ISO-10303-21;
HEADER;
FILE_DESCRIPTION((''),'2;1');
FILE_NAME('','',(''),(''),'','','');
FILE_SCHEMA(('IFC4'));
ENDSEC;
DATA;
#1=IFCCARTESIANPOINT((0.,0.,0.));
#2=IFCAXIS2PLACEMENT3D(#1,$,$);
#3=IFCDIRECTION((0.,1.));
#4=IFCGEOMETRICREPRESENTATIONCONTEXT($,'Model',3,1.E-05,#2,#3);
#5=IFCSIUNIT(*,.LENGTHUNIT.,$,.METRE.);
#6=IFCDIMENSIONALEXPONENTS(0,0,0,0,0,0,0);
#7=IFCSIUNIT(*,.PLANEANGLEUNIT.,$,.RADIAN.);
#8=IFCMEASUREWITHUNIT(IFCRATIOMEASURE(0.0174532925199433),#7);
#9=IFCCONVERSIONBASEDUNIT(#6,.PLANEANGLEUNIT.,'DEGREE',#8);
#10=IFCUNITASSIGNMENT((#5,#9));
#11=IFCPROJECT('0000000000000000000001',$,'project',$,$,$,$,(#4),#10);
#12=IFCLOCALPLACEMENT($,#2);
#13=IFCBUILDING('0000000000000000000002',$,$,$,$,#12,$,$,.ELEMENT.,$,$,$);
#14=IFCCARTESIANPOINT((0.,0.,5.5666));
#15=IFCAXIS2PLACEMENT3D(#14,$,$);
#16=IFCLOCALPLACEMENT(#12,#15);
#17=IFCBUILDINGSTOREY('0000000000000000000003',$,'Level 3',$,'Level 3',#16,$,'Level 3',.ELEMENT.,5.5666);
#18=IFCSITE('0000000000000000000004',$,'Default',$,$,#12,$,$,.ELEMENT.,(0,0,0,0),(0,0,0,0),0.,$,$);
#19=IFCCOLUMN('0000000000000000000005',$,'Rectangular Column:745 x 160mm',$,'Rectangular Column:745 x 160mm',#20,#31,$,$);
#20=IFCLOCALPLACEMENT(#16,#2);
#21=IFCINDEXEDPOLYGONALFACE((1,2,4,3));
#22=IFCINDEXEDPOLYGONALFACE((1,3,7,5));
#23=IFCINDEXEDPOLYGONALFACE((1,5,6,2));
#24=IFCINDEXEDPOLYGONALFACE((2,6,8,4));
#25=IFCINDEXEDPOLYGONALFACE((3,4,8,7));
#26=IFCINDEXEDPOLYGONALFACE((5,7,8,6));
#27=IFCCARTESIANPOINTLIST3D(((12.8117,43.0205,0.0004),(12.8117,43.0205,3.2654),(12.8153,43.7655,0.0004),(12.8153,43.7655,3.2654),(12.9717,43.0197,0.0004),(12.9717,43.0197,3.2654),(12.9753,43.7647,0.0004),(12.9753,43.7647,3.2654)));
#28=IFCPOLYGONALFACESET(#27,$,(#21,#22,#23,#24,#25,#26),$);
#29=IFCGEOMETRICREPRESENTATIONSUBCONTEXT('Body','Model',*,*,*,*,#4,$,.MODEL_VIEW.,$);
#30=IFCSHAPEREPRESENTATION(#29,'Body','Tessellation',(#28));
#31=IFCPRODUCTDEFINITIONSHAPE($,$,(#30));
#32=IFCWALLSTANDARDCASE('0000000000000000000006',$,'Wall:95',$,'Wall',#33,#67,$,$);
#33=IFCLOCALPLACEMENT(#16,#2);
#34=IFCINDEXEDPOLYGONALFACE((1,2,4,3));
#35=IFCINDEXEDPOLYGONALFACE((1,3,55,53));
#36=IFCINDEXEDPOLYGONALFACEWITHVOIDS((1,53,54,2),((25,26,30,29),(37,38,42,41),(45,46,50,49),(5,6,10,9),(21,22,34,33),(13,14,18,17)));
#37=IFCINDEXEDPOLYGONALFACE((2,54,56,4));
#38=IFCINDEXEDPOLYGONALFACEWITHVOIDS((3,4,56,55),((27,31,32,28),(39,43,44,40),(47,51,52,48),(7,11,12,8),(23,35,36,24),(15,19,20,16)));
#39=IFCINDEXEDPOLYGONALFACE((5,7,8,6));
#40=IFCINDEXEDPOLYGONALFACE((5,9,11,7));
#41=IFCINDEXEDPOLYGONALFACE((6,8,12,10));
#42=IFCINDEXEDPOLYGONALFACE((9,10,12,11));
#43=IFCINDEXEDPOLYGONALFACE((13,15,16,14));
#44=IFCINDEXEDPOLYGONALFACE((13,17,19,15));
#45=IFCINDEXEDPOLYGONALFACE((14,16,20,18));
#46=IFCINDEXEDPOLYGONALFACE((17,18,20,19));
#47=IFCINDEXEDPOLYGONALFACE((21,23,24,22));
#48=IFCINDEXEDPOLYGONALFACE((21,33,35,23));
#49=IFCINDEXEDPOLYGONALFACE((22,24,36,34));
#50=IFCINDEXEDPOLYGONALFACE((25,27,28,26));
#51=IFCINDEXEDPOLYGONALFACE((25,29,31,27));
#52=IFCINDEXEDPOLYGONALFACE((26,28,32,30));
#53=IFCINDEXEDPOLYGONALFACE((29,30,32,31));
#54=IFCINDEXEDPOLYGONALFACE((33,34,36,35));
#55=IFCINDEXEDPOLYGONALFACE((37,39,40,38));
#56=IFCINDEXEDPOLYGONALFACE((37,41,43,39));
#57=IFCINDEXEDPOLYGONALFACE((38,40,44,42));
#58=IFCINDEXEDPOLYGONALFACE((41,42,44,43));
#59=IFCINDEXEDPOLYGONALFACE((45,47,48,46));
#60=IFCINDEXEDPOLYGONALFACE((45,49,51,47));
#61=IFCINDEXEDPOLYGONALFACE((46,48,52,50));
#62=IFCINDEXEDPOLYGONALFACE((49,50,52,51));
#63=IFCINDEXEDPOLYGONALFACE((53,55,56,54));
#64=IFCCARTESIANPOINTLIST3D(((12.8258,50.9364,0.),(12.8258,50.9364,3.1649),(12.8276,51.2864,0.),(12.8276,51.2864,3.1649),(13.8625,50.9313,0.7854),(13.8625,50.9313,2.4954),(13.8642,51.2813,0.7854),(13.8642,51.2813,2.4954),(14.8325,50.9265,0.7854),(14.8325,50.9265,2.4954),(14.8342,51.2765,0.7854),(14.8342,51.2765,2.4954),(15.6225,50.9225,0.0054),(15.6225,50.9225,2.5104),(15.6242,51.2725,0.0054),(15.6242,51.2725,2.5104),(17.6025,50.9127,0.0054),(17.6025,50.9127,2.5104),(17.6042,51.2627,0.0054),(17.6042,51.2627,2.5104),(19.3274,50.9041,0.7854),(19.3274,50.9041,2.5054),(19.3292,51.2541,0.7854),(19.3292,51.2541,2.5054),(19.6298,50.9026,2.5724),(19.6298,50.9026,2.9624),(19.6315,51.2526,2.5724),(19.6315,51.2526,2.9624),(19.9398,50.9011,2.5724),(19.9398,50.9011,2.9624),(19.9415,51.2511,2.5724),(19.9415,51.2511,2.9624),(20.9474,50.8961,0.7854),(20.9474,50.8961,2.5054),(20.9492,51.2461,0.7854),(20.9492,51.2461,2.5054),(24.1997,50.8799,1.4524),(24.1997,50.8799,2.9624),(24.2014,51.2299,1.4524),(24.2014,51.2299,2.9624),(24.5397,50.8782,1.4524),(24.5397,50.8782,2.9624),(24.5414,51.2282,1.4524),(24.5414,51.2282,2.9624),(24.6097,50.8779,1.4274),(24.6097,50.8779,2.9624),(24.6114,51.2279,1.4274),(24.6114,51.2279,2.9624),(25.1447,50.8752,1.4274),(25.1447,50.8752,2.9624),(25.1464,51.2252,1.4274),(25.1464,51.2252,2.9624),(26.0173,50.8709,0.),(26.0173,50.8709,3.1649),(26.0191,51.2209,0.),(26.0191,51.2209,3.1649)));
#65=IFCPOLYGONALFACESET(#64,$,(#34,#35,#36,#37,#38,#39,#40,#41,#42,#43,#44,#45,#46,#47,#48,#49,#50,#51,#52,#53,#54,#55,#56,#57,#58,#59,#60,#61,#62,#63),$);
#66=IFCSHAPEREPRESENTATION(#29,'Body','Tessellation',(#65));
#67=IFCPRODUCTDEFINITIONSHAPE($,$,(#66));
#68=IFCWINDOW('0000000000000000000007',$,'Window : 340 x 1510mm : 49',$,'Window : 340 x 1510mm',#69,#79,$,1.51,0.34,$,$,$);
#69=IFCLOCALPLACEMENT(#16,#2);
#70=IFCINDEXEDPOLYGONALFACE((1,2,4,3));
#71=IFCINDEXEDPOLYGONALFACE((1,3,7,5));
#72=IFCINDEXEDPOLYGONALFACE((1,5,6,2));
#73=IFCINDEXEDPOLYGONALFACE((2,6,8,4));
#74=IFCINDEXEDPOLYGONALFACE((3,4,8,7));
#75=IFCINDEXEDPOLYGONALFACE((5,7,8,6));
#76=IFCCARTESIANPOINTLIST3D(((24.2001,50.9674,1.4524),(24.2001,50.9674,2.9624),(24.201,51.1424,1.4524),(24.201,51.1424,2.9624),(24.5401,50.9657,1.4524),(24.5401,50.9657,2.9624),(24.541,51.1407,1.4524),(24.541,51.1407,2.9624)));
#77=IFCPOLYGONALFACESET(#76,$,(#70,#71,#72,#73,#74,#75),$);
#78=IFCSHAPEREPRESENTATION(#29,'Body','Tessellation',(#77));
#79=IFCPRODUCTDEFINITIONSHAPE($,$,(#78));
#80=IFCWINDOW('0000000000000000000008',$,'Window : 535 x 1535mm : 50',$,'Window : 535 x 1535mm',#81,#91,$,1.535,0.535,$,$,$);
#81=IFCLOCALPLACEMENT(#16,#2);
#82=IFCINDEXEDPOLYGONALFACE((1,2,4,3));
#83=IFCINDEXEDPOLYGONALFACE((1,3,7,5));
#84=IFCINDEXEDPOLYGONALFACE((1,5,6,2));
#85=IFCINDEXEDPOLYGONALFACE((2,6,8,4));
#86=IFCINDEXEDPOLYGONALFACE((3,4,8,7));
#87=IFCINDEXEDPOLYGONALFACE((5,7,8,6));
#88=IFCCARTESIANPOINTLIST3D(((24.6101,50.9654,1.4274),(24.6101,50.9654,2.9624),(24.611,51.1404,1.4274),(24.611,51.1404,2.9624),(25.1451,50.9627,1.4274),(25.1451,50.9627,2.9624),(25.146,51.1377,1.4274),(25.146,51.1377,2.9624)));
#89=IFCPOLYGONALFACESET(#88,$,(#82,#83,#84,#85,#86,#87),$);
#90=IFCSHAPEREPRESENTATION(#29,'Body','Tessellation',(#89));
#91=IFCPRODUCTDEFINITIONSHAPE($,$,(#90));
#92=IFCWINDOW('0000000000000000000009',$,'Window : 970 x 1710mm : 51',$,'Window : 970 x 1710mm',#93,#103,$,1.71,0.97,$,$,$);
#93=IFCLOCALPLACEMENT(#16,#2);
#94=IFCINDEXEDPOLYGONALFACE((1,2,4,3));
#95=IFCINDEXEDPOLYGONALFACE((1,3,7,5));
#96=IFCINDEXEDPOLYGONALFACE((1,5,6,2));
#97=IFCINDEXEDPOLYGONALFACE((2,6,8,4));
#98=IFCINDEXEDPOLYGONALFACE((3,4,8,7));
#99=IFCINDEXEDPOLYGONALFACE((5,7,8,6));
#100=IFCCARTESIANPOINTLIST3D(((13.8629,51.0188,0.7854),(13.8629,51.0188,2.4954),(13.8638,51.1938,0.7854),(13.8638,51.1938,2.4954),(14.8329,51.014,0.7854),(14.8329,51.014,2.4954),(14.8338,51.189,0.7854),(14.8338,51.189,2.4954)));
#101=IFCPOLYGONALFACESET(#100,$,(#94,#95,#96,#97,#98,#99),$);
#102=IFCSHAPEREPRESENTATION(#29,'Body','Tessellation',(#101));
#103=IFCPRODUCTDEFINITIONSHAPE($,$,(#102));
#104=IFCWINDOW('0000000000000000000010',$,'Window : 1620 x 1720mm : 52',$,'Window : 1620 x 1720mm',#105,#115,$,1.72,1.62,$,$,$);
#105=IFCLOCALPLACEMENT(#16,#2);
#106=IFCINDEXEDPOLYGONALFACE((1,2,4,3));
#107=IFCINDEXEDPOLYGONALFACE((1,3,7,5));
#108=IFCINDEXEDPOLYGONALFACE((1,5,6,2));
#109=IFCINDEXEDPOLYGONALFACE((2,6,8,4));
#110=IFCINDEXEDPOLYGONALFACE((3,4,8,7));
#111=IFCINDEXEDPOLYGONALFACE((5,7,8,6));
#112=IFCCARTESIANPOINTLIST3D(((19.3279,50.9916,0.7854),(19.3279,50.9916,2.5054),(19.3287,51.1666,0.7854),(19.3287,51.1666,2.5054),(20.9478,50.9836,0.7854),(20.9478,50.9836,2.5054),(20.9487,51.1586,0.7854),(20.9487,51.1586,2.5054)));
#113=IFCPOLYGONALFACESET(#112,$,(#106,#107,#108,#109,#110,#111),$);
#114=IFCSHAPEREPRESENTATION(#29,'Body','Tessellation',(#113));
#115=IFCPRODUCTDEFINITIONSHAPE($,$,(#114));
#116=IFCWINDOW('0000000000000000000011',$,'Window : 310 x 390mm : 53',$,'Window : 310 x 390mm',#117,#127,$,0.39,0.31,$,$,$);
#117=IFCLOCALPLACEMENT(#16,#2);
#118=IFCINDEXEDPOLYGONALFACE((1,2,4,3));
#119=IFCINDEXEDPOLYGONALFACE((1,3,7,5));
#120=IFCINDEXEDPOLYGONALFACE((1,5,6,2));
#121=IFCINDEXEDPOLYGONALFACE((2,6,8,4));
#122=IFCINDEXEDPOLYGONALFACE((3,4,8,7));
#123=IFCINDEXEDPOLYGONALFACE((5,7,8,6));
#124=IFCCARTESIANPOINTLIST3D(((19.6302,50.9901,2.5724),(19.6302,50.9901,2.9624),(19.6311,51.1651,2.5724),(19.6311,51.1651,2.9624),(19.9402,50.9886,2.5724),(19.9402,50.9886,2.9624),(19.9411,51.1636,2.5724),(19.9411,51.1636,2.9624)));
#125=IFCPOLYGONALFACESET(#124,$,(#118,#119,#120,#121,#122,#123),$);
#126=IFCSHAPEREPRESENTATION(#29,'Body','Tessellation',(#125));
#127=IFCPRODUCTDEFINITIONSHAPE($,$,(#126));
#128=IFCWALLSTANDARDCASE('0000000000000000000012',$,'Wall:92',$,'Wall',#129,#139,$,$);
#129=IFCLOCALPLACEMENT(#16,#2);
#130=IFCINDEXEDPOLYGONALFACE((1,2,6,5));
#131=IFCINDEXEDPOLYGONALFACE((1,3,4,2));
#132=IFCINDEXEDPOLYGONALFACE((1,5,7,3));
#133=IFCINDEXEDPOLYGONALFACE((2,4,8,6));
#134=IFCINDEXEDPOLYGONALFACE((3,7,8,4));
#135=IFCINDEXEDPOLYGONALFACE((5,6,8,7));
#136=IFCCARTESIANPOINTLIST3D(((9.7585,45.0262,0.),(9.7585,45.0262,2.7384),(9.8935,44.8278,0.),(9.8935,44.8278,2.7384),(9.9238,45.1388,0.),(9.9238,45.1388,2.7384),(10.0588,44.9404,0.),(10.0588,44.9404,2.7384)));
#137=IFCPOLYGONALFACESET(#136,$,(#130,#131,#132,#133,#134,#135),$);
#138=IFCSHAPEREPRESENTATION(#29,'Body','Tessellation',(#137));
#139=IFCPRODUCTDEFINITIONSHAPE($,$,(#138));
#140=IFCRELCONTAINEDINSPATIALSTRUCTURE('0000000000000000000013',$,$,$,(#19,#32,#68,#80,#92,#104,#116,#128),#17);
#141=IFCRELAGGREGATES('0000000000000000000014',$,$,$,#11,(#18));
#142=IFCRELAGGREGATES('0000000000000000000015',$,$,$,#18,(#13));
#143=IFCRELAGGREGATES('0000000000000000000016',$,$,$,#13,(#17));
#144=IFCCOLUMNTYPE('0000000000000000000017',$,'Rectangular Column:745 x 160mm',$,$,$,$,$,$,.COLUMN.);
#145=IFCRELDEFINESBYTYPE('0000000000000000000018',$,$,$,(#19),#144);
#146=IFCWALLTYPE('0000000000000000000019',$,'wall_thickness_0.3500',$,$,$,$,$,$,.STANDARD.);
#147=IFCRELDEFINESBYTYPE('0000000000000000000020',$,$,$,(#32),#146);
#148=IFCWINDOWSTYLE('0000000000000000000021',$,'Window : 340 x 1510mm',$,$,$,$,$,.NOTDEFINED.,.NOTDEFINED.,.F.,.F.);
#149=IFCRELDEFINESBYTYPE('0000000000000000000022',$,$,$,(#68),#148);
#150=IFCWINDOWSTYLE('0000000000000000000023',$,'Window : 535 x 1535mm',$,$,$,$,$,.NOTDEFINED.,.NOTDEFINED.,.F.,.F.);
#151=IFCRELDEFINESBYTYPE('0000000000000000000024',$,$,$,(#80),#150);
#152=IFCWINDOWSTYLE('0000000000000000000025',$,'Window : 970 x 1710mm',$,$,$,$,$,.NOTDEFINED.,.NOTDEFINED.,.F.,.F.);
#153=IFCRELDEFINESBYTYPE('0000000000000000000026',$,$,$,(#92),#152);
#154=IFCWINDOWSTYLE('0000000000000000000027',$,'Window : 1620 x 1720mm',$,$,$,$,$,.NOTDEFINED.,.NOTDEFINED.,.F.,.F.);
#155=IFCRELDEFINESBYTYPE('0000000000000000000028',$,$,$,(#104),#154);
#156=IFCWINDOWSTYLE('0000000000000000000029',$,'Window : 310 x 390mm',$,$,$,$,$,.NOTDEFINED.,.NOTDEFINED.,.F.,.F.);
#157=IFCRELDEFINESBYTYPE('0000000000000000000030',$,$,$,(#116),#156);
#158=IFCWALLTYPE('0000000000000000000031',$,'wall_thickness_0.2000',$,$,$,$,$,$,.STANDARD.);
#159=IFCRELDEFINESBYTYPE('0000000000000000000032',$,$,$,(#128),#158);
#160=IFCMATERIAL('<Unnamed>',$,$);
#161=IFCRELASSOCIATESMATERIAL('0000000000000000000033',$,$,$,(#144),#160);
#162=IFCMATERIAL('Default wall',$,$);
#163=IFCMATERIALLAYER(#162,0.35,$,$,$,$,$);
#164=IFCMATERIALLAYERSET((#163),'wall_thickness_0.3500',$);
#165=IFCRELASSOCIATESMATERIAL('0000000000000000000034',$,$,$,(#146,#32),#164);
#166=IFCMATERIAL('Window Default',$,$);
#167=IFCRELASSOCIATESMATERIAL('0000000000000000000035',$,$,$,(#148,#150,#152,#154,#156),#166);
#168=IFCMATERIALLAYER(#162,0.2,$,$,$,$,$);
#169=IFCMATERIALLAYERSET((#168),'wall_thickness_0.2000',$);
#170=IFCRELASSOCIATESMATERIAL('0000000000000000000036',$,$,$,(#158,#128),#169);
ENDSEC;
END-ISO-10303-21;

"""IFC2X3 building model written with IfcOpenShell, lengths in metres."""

from ifc_helpers import new_model, entity, si_unit, converted_unit, direction, frame, frame_2d, origin, origin_2d_with_axis, place, context, subcontext, project, spatial, polyline, rectangle, outline, extrude, source, transform, mapped, material, layer, layer_set, layer_usage, type_object, type_shapes, element, fill, save


model = new_model("IFC2X3")

# Units and contexts
model_context = context("Model", 3, precision=1e-05, world=origin(), true_north=direction((0.0, 1.0)))
body_context = subcontext(model_context, "Body", "Model", "MODEL_VIEW")
ifc_project = project(units=[si_unit("LENGTHUNIT", "METRE"), converted_unit("PLANEANGLEUNIT", "DEGREE", entity("IfcRatioMeasure", 0.0174532925199433), si_unit("PLANEANGLEUNIT", "RADIAN"), dimensions=[0, 0, 0, 0, 0, 0, 0])], contexts=[model_context])

# Site, building, storey
placement = place(None, origin())
site = spatial("IfcSite", under=ifc_project, at=placement, Name="Default", CompositionType="ELEMENT", RefLatitude=(0, 0, 0, 0), RefLongitude=(0, 0, 0, 0), RefElevation=0.0)
building = spatial("IfcBuilding", under=site, at=placement, CompositionType="ELEMENT")
storey_placement = place(placement, frame((0.0, 0.0, 5.5666)))
storey = spatial("IfcBuildingStorey", under=building, at=storey_placement, Name="Level 3", ObjectType="Level 3", LongName="Level 3", CompositionType="ELEMENT", Elevation=5.5666)

# Column
ifc_material_1 = material(Name="<Unnamed>")
column_type = type_object("IfcColumnType", Name="Rectangular Column:745 x 160mm", PredefinedType="COLUMN", material=ifc_material_1)
shared_shape_1 = source(origin(), body_context, "Body", "SweptSolid", [
    extrude(rectangle(XDim=0.745, YDim=0.16, at=origin_2d_with_axis()), frame((0.0, 0.0, 0.0), z_axis=(0.0, 0.0, 1.0), x_axis=(0.0, -1.0, 0.0)), (0.0, 0.0, 1.0), 3.265),
])
type_shapes(column_type, [shared_shape_1])
column_placement = place(placement, frame((12.8935, 43.3926, 5.567), z_axis=(0.0, 0.0, 1.0), x_axis=(0.999988, -0.004948, 0.0)))
element("IfcColumn", 1, at=column_placement, inside=storey, type_object=column_type, Name="Rectangular Column:745 x 160mm", ObjectType="Rectangular Column:745 x 160mm", context=body_context, shape_type="MappedRepresentation", body=[
    mapped(shared_shape_1, transform((0.0, 0.0, 0.0), scale=1.0)),
])

# Wall, openings, windows
ifc_material_2 = material(Name="Default wall")
ifc_layer_1 = layer(ifc_material_2, 0.35)
ifc_layer_set_1 = layer_set([ifc_layer_1], Name="wall_thickness_0.3500")
ifc_layer_usage_1 = layer_usage(ifc_layer_set_1, "AXIS2", "POSITIVE", -0.175)
wall_type_1 = type_object("IfcWallType", Name="wall_thickness_0.3500", PredefinedType="STANDARD", material=ifc_layer_set_1)
wall_1_placement = place(storey_placement, frame((12.8267, 51.1114, 0.0), z_axis=(0.0, 0.0, 1.0), x_axis=(0.999988, -0.00497, 0.0)))
wall_1 = element("IfcWallStandardCase", 2, at=wall_1_placement, inside=storey, type_object=wall_type_1, material=ifc_layer_usage_1, Name="Wall:95", ObjectType="Wall", context=body_context, shape_type="SweptSolid", body=[
    extrude(outline(polyline([(13.1917, -0.175), (13.1917, 0.175), (0.0, 0.175), (0.0, -0.175), (13.1917, -0.175)])), origin(), (0.0, 0.0, 1.0), 3.1649),
])
opening_1_placement = place(wall_1_placement, frame((2.7967, -0.175, 0.0054)))
element("IfcOpeningElement", 3, at=opening_1_placement, cuts=wall_1, ObjectType="Opening", context=body_context, shape_type="SweptSolid", body=[
    extrude(rectangle(XDim=1.98, YDim=2.505, at=frame_2d((1.2525, 0.99), x_axis=(0.0, 1.0))), frame((0.0, 0.0, 0.0), z_axis=(0.0, 1.0, 0.0), x_axis=(0.0, 0.0, 1.0)), (0.0, 0.0, 1.0), 0.35),
])
opening_2_placement = place(wall_1_placement, frame((11.374, -0.175, 1.4524)))
opening_2 = element("IfcOpeningElement", 4, at=opening_2_placement, cuts=wall_1, ObjectType="Opening", context=body_context, shape_type="SweptSolid", body=[
    extrude(rectangle(XDim=0.34, YDim=1.51, at=frame_2d((0.755, 0.17), x_axis=(0.0, 1.0))), frame((0.0, 0.0, 0.0), z_axis=(0.0, 1.0, 0.0), x_axis=(0.0, 0.0, 1.0)), (0.0, 0.0, 1.0), 0.35),
])
opening_3_placement = place(wall_1_placement, frame((11.784, -0.175, 1.4274)))
opening_3 = element("IfcOpeningElement", 5, at=opening_3_placement, cuts=wall_1, ObjectType="Opening", context=body_context, shape_type="SweptSolid", body=[
    extrude(rectangle(XDim=0.535, YDim=1.535, at=frame_2d((0.7675, 0.2675), x_axis=(0.0, 1.0))), frame((0.0, 0.0, 0.0), z_axis=(0.0, 1.0, 0.0), x_axis=(0.0, 0.0, 1.0)), (0.0, 0.0, 1.0), 0.35),
])
opening_4_placement = place(wall_1_placement, frame((1.0367, -0.175, 0.7854)))
opening_4 = element("IfcOpeningElement", 6, at=opening_4_placement, cuts=wall_1, ObjectType="Opening", context=body_context, shape_type="SweptSolid", body=[
    extrude(rectangle(XDim=0.97, YDim=1.71, at=frame_2d((0.855, 0.485), x_axis=(0.0, 1.0))), frame((0.0, 0.0, 0.0), z_axis=(0.0, 1.0, 0.0), x_axis=(0.0, 0.0, 1.0)), (0.0, 0.0, 1.0), 0.35),
])
opening_5_placement = place(wall_1_placement, frame((6.5017, -0.175, 0.7854)))
opening_5 = element("IfcOpeningElement", 7, at=opening_5_placement, cuts=wall_1, ObjectType="Opening", context=body_context, shape_type="SweptSolid", body=[
    extrude(rectangle(XDim=1.62, YDim=1.72, at=frame_2d((0.86, 0.81), x_axis=(0.0, 1.0))), frame((0.0, 0.0, 0.0), z_axis=(0.0, 1.0, 0.0), x_axis=(0.0, 0.0, 1.0)), (0.0, 0.0, 1.0), 0.35),
])
opening_6_placement = place(wall_1_placement, frame((6.804, -0.175, 2.5724)))
opening_6 = element("IfcOpeningElement", 8, at=opening_6_placement, cuts=wall_1, ObjectType="Opening", context=body_context, shape_type="SweptSolid", body=[
    extrude(rectangle(XDim=0.31, YDim=0.39, at=frame_2d((0.195, 0.155), x_axis=(0.0, 1.0))), frame((0.0, 0.0, 0.0), z_axis=(0.0, 1.0, 0.0), x_axis=(0.0, 0.0, 1.0)), (0.0, 0.0, 1.0), 0.35),
])
ifc_material_3 = material(Name="Window Default")
window_style_1 = type_object("IfcWindowStyle", Name="Window : 340 x 1510mm", ConstructionType="NOTDEFINED", OperationType="NOTDEFINED", ParameterTakesPrecedence=False, Sizeable=False, material=ifc_material_3)
shared_shape_2 = source(origin(), body_context, "Body", "SweptSolid", [
    extrude(rectangle(XDim=0.175, YDim=0.34, at=origin_2d_with_axis()), frame((0.17, 0.175, 0.0), z_axis=(0.0, 0.0, 1.0), x_axis=(0.0, 1.0, 0.0)), (0.0, 0.0, 1.0), 1.51),
])
type_shapes(window_style_1, [shared_shape_2])
window_1_placement = place(opening_2_placement, origin())
window_1 = element("IfcWindow", 9, at=window_1_placement, inside=storey, type_object=window_style_1, Name="Window : 340 x 1510mm : 49", ObjectType="Window : 340 x 1510mm", OverallHeight=1.51, OverallWidth=0.34, context=body_context, shape_type="MappedRepresentation", body=[
    mapped(shared_shape_2, transform((0.0, 0.0, 0.0), scale=1.0)),
])
fill(opening_2, window_1)
window_style_2 = type_object("IfcWindowStyle", Name="Window : 535 x 1535mm", ConstructionType="NOTDEFINED", OperationType="NOTDEFINED", ParameterTakesPrecedence=False, Sizeable=False, material=ifc_material_3)
shared_shape_3 = source(origin(), body_context, "Body", "SweptSolid", [
    extrude(rectangle(XDim=0.175, YDim=0.535, at=origin_2d_with_axis()), frame((0.2675, 0.175, 0.0), z_axis=(0.0, 0.0, 1.0), x_axis=(0.0, 1.0, 0.0)), (0.0, 0.0, 1.0), 1.535),
])
type_shapes(window_style_2, [shared_shape_3])
window_2_placement = place(opening_3_placement, origin())
window_2 = element("IfcWindow", 10, at=window_2_placement, inside=storey, type_object=window_style_2, Name="Window : 535 x 1535mm : 50", ObjectType="Window : 535 x 1535mm", OverallHeight=1.535, OverallWidth=0.535, context=body_context, shape_type="MappedRepresentation", body=[
    mapped(shared_shape_3, transform((0.0, 0.0, 0.0), scale=1.0)),
])
fill(opening_3, window_2)
window_style_3 = type_object("IfcWindowStyle", Name="Window : 970 x 1710mm", ConstructionType="NOTDEFINED", OperationType="NOTDEFINED", ParameterTakesPrecedence=False, Sizeable=False, material=ifc_material_3)
shared_shape_4 = source(origin(), body_context, "Body", "SweptSolid", [
    extrude(rectangle(XDim=0.175, YDim=0.97, at=origin_2d_with_axis()), frame((0.485, 0.175, 0.0), z_axis=(0.0, 0.0, 1.0), x_axis=(0.0, 1.0, 0.0)), (0.0, 0.0, 1.0), 1.71),
])
type_shapes(window_style_3, [shared_shape_4])
window_3_placement = place(opening_4_placement, origin())
window_3 = element("IfcWindow", 11, at=window_3_placement, inside=storey, type_object=window_style_3, Name="Window : 970 x 1710mm : 51", ObjectType="Window : 970 x 1710mm", OverallHeight=1.71, OverallWidth=0.97, context=body_context, shape_type="MappedRepresentation", body=[
    mapped(shared_shape_4, transform((0.0, 0.0, 0.0), scale=1.0)),
])
fill(opening_4, window_3)
window_style_4 = type_object("IfcWindowStyle", Name="Window : 1620 x 1720mm", ConstructionType="NOTDEFINED", OperationType="NOTDEFINED", ParameterTakesPrecedence=False, Sizeable=False, material=ifc_material_3)
shared_shape_5 = source(origin(), body_context, "Body", "SweptSolid", [
    extrude(rectangle(XDim=0.175, YDim=1.62, at=origin_2d_with_axis()), frame((0.81, 0.175, 0.0), z_axis=(0.0, 0.0, 1.0), x_axis=(0.0, 1.0, 0.0)), (0.0, 0.0, 1.0), 1.72),
])
type_shapes(window_style_4, [shared_shape_5])
window_4_placement = place(opening_5_placement, origin())
window_4 = element("IfcWindow", 12, at=window_4_placement, inside=storey, type_object=window_style_4, Name="Window : 1620 x 1720mm : 52", ObjectType="Window : 1620 x 1720mm", OverallHeight=1.72, OverallWidth=1.62, context=body_context, shape_type="MappedRepresentation", body=[
    mapped(shared_shape_5, transform((0.0, 0.0, 0.0), scale=1.0)),
])
fill(opening_5, window_4)
window_style_5 = type_object("IfcWindowStyle", Name="Window : 310 x 390mm", ConstructionType="NOTDEFINED", OperationType="NOTDEFINED", ParameterTakesPrecedence=False, Sizeable=False, material=ifc_material_3)
shared_shape_6 = source(origin(), body_context, "Body", "SweptSolid", [
    extrude(rectangle(XDim=0.175, YDim=0.31, at=origin_2d_with_axis()), frame((0.155, 0.175, 0.0), z_axis=(0.0, 0.0, 1.0), x_axis=(0.0, 1.0, 0.0)), (0.0, 0.0, 1.0), 0.39),
])
type_shapes(window_style_5, [shared_shape_6])
window_5_placement = place(opening_6_placement, origin())
window_5 = element("IfcWindow", 13, at=window_5_placement, inside=storey, type_object=window_style_5, Name="Window : 310 x 390mm : 53", ObjectType="Window : 310 x 390mm", OverallHeight=0.39, OverallWidth=0.31, context=body_context, shape_type="MappedRepresentation", body=[
    mapped(shared_shape_6, transform((0.0, 0.0, 0.0), scale=1.0)),
])
fill(opening_6, window_5)

# Wall
ifc_layer_2 = layer(ifc_material_2, 0.2)
ifc_layer_set_2 = layer_set([ifc_layer_2], Name="wall_thickness_0.2000")
ifc_layer_usage_2 = layer_usage(ifc_layer_set_2, "AXIS2", "POSITIVE", -0.1)
wall_type_2 = type_object("IfcWallType", Name="wall_thickness_0.2000", PredefinedType="STANDARD", material=ifc_layer_set_2)
wall_2_placement = place(storey_placement, frame((9.8411, 45.0825, 0.0), z_axis=(0.0, 0.0, 1.0), x_axis=(0.562715, -0.826651, 0.0)))
element("IfcWallStandardCase", 14, at=wall_2_placement, inside=storey, type_object=wall_type_2, material=ifc_layer_usage_2, Name="Wall:92", ObjectType="Wall", context=body_context, shape_type="SweptSolid", body=[
    extrude(outline(polyline([(0.24, -0.1), (0.24, 0.1), (0.0, 0.1), (0.0, -0.1), (0.24, -0.1)])), origin(), (0.0, 0.0, 1.0), 2.7384),
])

save(model, "model.ifc")
